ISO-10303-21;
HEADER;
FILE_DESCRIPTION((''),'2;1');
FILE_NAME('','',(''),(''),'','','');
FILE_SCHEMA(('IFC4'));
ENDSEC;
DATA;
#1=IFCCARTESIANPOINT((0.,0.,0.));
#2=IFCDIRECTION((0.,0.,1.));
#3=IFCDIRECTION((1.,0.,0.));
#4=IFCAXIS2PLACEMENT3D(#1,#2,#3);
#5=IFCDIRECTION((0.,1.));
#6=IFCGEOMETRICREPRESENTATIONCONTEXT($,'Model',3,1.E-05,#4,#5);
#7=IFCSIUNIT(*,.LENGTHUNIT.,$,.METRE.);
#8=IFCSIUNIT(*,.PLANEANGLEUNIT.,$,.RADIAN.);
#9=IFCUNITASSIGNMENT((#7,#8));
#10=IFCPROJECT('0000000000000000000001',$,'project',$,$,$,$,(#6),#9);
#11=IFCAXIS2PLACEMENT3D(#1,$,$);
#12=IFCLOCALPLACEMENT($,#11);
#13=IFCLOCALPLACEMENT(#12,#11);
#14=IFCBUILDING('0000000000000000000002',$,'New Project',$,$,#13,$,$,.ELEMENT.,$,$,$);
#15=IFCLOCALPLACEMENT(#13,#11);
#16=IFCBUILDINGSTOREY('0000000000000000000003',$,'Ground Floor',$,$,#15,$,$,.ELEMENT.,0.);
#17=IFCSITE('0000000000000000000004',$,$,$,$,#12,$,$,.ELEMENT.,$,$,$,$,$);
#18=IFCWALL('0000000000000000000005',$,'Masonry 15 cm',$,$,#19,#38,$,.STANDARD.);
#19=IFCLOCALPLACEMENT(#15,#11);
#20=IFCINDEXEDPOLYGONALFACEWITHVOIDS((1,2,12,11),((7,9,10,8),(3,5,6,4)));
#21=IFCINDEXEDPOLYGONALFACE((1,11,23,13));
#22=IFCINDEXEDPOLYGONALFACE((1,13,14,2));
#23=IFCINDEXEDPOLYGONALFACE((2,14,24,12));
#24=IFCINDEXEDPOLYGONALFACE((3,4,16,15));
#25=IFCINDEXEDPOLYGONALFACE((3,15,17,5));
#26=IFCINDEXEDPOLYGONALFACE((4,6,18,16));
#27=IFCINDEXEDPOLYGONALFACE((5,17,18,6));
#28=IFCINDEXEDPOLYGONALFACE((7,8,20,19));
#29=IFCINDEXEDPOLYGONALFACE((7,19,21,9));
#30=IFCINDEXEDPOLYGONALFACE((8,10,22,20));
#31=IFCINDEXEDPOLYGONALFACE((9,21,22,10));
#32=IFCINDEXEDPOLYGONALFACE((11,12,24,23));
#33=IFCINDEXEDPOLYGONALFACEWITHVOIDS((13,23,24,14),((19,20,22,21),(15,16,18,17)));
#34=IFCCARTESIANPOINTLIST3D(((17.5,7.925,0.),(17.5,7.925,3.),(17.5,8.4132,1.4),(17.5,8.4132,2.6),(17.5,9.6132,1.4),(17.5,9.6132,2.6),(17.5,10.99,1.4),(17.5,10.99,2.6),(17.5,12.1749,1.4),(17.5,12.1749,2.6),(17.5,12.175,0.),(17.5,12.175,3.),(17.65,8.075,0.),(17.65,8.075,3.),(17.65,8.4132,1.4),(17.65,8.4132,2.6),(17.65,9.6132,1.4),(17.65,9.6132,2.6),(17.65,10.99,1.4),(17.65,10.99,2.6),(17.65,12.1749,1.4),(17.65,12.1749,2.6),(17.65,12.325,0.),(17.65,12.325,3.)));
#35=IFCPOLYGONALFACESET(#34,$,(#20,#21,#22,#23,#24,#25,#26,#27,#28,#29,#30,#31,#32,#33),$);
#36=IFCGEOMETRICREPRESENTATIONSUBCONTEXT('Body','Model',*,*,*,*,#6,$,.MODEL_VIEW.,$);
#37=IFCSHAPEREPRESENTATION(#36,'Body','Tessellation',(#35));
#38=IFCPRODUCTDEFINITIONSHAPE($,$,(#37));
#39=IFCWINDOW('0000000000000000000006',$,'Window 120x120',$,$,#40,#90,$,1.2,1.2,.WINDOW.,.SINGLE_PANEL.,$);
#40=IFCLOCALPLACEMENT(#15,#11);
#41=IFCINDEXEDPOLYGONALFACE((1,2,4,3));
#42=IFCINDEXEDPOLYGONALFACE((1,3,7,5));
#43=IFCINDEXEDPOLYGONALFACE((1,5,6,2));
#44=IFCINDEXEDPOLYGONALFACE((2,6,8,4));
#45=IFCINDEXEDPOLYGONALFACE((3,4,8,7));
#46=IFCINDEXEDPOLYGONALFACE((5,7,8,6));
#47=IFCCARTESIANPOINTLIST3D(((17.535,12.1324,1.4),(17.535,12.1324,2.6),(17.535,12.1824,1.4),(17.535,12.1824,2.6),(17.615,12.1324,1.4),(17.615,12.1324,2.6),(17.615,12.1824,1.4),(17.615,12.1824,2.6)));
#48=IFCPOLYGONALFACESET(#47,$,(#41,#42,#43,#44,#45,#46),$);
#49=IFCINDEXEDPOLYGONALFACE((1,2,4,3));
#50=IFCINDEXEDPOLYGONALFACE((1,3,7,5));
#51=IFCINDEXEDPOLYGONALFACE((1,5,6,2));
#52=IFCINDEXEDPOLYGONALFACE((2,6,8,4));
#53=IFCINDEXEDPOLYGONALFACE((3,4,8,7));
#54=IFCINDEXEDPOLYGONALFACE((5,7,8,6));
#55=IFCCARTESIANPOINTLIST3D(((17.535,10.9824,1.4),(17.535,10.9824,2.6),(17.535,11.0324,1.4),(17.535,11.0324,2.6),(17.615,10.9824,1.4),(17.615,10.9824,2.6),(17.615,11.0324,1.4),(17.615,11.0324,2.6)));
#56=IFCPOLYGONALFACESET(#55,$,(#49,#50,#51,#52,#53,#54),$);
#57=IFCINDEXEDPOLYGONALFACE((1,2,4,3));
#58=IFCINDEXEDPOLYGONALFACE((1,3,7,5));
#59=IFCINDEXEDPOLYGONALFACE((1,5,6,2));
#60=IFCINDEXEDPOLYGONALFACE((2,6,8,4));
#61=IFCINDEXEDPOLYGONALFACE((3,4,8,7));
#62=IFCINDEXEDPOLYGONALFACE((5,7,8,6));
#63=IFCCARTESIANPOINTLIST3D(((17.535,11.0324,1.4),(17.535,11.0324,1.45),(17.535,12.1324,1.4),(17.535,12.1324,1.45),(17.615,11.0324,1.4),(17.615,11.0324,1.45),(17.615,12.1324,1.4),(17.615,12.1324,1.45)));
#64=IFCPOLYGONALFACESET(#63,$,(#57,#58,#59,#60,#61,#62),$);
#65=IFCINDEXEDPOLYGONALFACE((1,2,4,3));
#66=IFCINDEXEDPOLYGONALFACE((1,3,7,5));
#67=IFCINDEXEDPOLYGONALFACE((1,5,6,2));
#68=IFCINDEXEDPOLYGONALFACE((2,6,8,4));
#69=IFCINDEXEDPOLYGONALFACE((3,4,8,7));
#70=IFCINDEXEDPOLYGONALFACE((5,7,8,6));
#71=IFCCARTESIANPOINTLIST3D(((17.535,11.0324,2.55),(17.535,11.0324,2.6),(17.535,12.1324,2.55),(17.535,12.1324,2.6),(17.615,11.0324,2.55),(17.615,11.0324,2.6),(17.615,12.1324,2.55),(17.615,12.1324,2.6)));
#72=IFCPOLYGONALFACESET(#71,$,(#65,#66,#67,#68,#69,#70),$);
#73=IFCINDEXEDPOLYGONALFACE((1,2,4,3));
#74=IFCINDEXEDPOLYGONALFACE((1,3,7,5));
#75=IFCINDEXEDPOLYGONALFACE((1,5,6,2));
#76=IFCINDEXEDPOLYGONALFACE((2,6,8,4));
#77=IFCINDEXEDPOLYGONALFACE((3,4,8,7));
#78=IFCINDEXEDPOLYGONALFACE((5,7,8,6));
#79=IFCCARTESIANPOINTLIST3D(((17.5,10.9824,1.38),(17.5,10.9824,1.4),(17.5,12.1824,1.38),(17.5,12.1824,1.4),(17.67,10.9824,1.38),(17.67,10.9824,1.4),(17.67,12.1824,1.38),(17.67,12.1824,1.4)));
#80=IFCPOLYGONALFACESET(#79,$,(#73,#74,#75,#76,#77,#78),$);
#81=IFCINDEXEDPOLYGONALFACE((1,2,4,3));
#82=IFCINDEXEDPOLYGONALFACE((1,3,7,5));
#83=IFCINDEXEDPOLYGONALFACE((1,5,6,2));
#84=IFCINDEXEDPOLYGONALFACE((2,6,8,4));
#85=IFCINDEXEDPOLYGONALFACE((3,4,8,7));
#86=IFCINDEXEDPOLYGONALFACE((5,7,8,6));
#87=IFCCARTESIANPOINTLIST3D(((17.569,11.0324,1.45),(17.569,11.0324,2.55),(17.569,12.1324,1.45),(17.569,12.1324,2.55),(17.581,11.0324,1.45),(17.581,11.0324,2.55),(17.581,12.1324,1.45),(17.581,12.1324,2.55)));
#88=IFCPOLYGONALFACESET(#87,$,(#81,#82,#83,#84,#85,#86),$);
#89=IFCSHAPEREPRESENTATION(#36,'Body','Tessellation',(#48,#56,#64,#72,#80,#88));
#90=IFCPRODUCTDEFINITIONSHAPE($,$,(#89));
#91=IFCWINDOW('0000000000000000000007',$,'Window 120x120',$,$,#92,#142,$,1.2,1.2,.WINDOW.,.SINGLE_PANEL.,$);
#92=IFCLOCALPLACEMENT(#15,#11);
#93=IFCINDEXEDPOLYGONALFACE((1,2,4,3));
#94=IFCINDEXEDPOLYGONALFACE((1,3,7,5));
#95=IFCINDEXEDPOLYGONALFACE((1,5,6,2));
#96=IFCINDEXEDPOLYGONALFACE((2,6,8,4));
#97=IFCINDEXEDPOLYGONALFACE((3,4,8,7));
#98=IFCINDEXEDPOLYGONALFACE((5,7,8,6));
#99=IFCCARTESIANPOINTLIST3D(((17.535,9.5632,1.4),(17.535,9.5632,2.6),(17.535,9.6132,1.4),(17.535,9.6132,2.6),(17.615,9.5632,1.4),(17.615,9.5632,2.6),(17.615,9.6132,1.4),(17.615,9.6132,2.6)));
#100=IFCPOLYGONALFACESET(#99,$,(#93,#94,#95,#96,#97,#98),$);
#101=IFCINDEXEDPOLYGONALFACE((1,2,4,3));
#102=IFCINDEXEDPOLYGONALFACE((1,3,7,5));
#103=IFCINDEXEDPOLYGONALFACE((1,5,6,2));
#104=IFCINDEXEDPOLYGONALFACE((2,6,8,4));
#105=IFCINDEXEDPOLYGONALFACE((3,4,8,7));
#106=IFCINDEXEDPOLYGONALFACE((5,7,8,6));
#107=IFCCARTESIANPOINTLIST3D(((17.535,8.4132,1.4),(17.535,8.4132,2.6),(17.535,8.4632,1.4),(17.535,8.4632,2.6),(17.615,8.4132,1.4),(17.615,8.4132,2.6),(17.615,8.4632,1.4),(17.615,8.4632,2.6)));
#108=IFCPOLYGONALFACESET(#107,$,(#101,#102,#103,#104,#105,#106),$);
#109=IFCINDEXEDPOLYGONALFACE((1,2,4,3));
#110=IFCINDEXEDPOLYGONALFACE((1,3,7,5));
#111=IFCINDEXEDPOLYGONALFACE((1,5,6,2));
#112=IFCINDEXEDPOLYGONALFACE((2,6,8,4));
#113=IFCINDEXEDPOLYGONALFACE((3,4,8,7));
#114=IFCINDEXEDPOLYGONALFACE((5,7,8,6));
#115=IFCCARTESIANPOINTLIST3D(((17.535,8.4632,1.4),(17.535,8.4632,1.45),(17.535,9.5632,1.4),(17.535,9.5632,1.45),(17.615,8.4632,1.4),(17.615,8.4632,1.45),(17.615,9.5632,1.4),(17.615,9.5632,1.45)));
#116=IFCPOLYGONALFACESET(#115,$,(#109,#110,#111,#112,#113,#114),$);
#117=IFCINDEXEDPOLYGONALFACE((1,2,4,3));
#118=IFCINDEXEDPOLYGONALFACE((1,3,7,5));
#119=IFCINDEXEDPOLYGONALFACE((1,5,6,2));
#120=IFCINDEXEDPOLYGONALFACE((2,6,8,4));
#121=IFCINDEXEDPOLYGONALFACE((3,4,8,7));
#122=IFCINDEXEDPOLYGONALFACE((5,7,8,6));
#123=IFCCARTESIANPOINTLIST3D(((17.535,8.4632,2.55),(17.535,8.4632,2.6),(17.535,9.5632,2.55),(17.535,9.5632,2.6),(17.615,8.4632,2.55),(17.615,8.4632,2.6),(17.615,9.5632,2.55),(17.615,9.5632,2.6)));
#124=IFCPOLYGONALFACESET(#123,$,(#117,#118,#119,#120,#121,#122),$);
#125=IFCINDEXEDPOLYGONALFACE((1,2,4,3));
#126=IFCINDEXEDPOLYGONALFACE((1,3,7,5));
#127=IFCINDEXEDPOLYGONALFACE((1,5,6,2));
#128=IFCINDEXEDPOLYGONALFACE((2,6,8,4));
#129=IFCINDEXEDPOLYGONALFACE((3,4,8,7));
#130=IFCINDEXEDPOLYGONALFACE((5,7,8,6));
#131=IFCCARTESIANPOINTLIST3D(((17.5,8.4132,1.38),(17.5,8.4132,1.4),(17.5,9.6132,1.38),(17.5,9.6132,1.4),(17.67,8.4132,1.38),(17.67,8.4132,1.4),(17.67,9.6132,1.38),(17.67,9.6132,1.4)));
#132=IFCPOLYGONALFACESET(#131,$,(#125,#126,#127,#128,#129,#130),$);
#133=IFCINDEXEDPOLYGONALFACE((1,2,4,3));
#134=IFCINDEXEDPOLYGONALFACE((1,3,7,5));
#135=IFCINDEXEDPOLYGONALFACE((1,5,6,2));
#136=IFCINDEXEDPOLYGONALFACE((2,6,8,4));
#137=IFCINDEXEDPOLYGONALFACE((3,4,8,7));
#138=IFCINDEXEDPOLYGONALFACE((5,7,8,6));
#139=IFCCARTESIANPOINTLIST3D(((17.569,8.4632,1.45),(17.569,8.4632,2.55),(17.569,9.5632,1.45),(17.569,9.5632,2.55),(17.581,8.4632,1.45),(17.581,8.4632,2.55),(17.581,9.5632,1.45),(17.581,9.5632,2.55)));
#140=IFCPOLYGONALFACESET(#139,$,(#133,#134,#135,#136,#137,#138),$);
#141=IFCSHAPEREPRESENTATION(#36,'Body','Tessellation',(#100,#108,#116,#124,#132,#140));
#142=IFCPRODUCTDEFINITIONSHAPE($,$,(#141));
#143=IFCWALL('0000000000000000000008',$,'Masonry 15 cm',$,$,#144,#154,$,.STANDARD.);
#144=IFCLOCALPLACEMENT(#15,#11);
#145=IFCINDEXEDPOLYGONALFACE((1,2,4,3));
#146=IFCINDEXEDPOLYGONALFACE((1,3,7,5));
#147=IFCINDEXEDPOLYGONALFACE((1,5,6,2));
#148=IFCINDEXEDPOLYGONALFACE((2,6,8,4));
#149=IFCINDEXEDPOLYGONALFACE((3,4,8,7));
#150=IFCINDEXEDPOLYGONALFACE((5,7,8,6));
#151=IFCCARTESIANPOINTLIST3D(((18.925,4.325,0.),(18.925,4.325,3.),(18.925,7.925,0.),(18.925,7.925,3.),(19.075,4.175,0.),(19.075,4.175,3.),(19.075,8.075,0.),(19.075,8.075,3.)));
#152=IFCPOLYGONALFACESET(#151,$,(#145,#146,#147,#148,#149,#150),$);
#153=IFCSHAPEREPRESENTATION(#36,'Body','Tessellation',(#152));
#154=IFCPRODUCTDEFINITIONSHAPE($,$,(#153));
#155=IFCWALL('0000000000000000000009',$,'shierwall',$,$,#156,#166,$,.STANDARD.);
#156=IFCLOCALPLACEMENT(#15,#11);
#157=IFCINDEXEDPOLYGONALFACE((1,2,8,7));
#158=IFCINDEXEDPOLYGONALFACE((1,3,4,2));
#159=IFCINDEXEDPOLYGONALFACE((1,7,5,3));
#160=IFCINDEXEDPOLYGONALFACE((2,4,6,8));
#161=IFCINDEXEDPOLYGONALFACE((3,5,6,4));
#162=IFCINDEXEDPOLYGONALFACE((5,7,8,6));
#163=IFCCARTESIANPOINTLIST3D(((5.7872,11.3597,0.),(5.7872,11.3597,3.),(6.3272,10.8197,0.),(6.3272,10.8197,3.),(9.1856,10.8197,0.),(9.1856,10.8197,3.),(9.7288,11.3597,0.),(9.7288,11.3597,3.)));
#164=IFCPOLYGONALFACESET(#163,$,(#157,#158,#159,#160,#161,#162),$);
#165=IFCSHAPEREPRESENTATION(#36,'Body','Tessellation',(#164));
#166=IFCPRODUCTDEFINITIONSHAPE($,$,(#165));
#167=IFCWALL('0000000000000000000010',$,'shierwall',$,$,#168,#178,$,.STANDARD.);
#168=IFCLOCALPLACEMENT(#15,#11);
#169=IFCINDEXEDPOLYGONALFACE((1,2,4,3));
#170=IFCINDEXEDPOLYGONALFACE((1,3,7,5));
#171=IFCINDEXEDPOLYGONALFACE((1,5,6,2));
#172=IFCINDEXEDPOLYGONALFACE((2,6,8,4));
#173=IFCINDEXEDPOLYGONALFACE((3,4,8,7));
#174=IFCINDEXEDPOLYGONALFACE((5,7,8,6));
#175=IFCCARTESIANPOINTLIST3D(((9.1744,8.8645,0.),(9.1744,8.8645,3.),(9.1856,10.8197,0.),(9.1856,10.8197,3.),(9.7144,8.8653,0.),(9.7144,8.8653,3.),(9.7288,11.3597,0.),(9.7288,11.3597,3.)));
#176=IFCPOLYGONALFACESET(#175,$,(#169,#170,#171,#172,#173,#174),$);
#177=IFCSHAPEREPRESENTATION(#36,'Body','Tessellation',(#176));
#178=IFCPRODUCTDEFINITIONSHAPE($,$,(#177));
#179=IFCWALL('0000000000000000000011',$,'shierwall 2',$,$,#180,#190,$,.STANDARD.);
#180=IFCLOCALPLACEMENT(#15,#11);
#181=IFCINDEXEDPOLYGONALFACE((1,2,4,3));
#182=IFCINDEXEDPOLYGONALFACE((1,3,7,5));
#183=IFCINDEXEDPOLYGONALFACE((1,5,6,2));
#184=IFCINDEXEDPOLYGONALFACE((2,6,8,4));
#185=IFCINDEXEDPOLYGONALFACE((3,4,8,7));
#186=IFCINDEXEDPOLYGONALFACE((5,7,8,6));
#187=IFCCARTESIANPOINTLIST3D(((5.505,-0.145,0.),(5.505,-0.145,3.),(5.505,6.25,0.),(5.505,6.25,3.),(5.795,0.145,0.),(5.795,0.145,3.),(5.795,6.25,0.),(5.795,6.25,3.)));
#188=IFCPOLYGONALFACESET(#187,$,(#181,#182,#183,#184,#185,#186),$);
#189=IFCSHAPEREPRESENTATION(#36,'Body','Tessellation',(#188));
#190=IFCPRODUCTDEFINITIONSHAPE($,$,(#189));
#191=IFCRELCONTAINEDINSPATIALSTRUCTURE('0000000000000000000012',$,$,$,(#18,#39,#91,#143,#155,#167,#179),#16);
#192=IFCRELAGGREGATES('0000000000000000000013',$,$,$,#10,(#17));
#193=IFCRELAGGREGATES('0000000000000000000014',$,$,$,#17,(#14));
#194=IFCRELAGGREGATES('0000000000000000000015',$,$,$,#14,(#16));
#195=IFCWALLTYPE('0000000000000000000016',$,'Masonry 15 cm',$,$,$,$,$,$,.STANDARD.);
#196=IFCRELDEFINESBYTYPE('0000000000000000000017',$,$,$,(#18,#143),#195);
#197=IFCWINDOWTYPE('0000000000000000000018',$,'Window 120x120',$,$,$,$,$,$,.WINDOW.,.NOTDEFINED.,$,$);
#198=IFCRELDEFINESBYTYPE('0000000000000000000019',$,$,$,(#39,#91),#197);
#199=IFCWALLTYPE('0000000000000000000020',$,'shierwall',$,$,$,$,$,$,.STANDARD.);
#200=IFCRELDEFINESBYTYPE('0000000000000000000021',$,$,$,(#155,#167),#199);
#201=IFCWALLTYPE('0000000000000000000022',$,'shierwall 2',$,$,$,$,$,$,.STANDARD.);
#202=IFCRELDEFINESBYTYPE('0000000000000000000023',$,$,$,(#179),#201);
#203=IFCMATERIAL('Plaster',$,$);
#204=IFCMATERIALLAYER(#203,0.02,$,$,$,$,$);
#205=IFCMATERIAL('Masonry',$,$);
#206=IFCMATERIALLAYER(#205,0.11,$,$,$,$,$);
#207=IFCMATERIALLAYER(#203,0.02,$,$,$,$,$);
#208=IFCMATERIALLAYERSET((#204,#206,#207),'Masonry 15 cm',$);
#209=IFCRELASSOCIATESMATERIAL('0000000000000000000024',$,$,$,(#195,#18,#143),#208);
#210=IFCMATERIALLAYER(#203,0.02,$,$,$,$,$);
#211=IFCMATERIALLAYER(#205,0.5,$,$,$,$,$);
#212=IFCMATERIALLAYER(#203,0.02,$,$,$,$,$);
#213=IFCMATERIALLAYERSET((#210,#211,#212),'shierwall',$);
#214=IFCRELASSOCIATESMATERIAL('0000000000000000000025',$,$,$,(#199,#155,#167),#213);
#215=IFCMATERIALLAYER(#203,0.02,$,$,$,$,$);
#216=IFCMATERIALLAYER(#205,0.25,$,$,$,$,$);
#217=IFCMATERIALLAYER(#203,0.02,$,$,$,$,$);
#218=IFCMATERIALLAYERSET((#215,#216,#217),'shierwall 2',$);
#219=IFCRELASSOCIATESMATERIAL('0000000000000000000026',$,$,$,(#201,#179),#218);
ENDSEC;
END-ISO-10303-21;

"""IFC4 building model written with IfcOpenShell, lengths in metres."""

from ifc_helpers import new_model, si_unit, direction, frame, frame_2d, origin, origin_with_axes, place, context, subcontext, project, spatial, polyline, rectangle, outline, extrude, material, layer, layer_set, layer_usage, type_object, element, fill, save


model = new_model("IFC4")

# Units and contexts
model_context = context("Model", 3, precision=1e-05, world=origin_with_axes(), true_north=direction((0.0, 1.0)))
body_context = subcontext(model_context, "Body", "Model", "MODEL_VIEW")
ifc_project = project(units=[si_unit("LENGTHUNIT", "METRE"), si_unit("PLANEANGLEUNIT", "RADIAN")], contexts=[model_context])

# Site, building, storey
site_placement = place(None, origin())
site = spatial("IfcSite", under=ifc_project, at=site_placement, CompositionType="ELEMENT")
building_placement = place(site_placement, origin())
building = spatial("IfcBuilding", under=site, at=building_placement, Name="New Project", CompositionType="ELEMENT")
storey_placement = place(building_placement, origin())
storey = spatial("IfcBuildingStorey", under=building, at=storey_placement, Name="Ground Floor", CompositionType="ELEMENT", Elevation=0.0)

# Shared definitions
ifc_material_1 = material(Name="Plaster")
ifc_layer_1 = layer(ifc_material_1, 0.02)
ifc_material_2 = material(Name="Masonry")
ifc_layer_2 = layer(ifc_material_2, 0.11)
ifc_layer_3 = layer(ifc_material_1, 0.02)
ifc_layer_set_1 = layer_set([ifc_layer_1, ifc_layer_2, ifc_layer_3], Name="Masonry 15 cm")
ifc_layer_usage_1 = layer_usage(ifc_layer_set_1, "AXIS2", "NEGATIVE", 0.075)
wall_type_1 = type_object("IfcWallType", Name="Masonry 15 cm", PredefinedType="STANDARD", material=ifc_layer_set_1)

# Shared definitions
window_type = type_object("IfcWindowType", Name="Window 120x120", PartitioningType="NOTDEFINED", PredefinedType="WINDOW")

# Wall, openings, windows
wall_1_placement = place(storey_placement, frame((17.575, 12.25, 0.0), z_axis=(0.0, 0.0, 1.0), x_axis=(0.0, -1.0, 0.0)))
wall_1 = element("IfcWall", 1, at=wall_1_placement, inside=storey, type_object=wall_type_1, material=ifc_layer_usage_1, Name="Masonry 15 cm", PredefinedType="STANDARD", context=body_context, shape_type="SweptSolid", body=[
    extrude(outline(polyline([(0.075, -0.075), (4.325, -0.075), (4.175, 0.075), (-0.075, 0.075), (0.075, -0.075)])), origin(), (0.0, 0.0, 1.0), 3.0),
])
opening_1_placement = place(wall_1_placement, frame((0.0751, 0.0, 1.4)))
opening_1 = element("IfcOpeningElement", 2, at=opening_1_placement, cuts=wall_1, PredefinedType="OPENING", context=body_context, shape_type="SweptSolid", body=[
    extrude(rectangle(XDim=1.1849, YDim=0.25, at=frame_2d((0.5925, 0.0))), origin(), (0.0, 0.0, 1.0), 1.2),
])
opening_2_placement = place(wall_1_placement, frame((2.6368, 0.0, 1.4)))
opening_2 = element("IfcOpeningElement", 3, at=opening_2_placement, cuts=wall_1, PredefinedType="OPENING", context=body_context, shape_type="SweptSolid", body=[
    extrude(rectangle(XDim=1.2, YDim=0.25, at=frame_2d((0.6, 0.0))), origin(), (0.0, 0.0, 1.0), 1.2),
])
window_1_placement = place(opening_1_placement, origin())
window_1 = element("IfcWindow", 4, at=window_1_placement, inside=storey, type_object=window_type, Name="Window 120x120", OverallHeight=1.2, OverallWidth=1.2, PartitioningType="SINGLE_PANEL", PredefinedType="WINDOW", context=body_context, shape_type="SweptSolid", body=[
    extrude(outline(polyline([(-0.0076, -0.04), (0.0425, -0.04), (0.0425, 0.04), (-0.0076, 0.04), (-0.0076, -0.04)])), origin(), (0.0, 0.0, 1.0), 1.2),
    extrude(outline(polyline([(1.1424, -0.04), (1.1925, -0.04), (1.1925, 0.04), (1.1424, 0.04), (1.1424, -0.04)])), origin(), (0.0, 0.0, 1.0), 1.2),
    extrude(outline(polyline([(0.0425, -0.04), (1.1424, -0.04), (1.1424, 0.04), (0.0425, 0.04), (0.0425, -0.04)])), origin(), (0.0, 0.0, 1.0), 0.05),
    extrude(outline(polyline([(0.0425, -0.04), (1.1424, -0.04), (1.1424, 0.04), (0.0425, 0.04), (0.0425, -0.04)])), frame((0.0, 0.0, 1.15)), (0.0, 0.0, 1.0), 0.05),
    extrude(outline(polyline([(-0.0076, -0.075), (1.1925, -0.075), (1.1925, 0.095), (-0.0076, 0.095), (-0.0076, -0.075)])), frame((0.0, 0.0, -0.02)), (0.0, 0.0, 1.0), 0.02),
    extrude(outline(polyline([(0.0425, -0.006), (1.1424, -0.006), (1.1424, 0.006), (0.0425, 0.006), (0.0425, -0.006)])), frame((0.0, 0.0, 0.05)), (0.0, 0.0, 1.0), 1.1),
])
fill(opening_1, window_1)
window_2_placement = place(opening_2_placement, origin())
window_2 = element("IfcWindow", 5, at=window_2_placement, inside=storey, type_object=window_type, Name="Window 120x120", OverallHeight=1.2, OverallWidth=1.2, PartitioningType="SINGLE_PANEL", PredefinedType="WINDOW", context=body_context, shape_type="SweptSolid", body=[
    extrude(outline(polyline([(0.0, -0.04), (0.05, -0.04), (0.05, 0.04), (0.0, 0.04), (0.0, -0.04)])), origin(), (0.0, 0.0, 1.0), 1.2),
    extrude(outline(polyline([(1.15, -0.04), (1.2, -0.04), (1.2, 0.04), (1.15, 0.04), (1.15, -0.04)])), origin(), (0.0, 0.0, 1.0), 1.2),
    extrude(outline(polyline([(0.05, -0.04), (1.15, -0.04), (1.15, 0.04), (0.05, 0.04), (0.05, -0.04)])), origin(), (0.0, 0.0, 1.0), 0.05),
    extrude(outline(polyline([(0.05, -0.04), (1.15, -0.04), (1.15, 0.04), (0.05, 0.04), (0.05, -0.04)])), frame((0.0, 0.0, 1.15)), (0.0, 0.0, 1.0), 0.05),
    extrude(outline(polyline([(0.0, -0.075), (1.2, -0.075), (1.2, 0.095), (0.0, 0.095), (0.0, -0.075)])), frame((0.0, 0.0, -0.02)), (0.0, 0.0, 1.0), 0.02),
    extrude(outline(polyline([(0.05, -0.006), (1.15, -0.006), (1.15, 0.006), (0.05, 0.006), (0.05, -0.006)])), frame((0.0, 0.0, 0.05)), (0.0, 0.0, 1.0), 1.1),
])
fill(opening_2, window_2)

# Walls
wall_2_placement = place(storey_placement, frame((19.0, 8.0, 0.0), z_axis=(0.0, 0.0, 1.0), x_axis=(0.0, -1.0, 0.0)))
element("IfcWall", 6, at=wall_2_placement, inside=storey, type_object=wall_type_1, material=ifc_layer_usage_1, Name="Masonry 15 cm", PredefinedType="STANDARD", context=body_context, shape_type="SweptSolid", body=[
    extrude(outline(polyline([(0.075, -0.075), (3.675, -0.075), (3.825, 0.075), (-0.075, 0.075), (0.075, -0.075)])), origin(), (0.0, 0.0, 1.0), 3.0),
])
ifc_layer_4 = layer(ifc_material_1, 0.02)
ifc_layer_5 = layer(ifc_material_2, 0.5)
ifc_layer_6 = layer(ifc_material_1, 0.02)
ifc_layer_set_2 = layer_set([ifc_layer_4, ifc_layer_5, ifc_layer_6], Name="shierwall")
ifc_layer_usage_2 = layer_usage(ifc_layer_set_2, "AXIS2", "NEGATIVE", 0.27)
wall_type_2 = type_object("IfcWallType", Name="shierwall", PredefinedType="STANDARD", material=ifc_layer_set_2)
wall_3_placement = place(storey_placement, frame((6.0572, 11.0897, 0.0)))
element("IfcWall", 7, at=wall_3_placement, inside=storey, type_object=wall_type_2, material=ifc_layer_usage_2, Name="shierwall", PredefinedType="STANDARD", context=body_context, shape_type="SweptSolid", body=[
    extrude(outline(polyline([(0.27, -0.27), (3.1284, -0.27), (3.6716, 0.27), (-0.27, 0.27), (0.27, -0.27)])), origin(), (0.0, 0.0, 1.0), 3.0),
])
wall_4_placement = place(storey_placement, frame((9.4572, 11.0897, 0.0), z_axis=(0.0, 0.0, 1.0), x_axis=(-0.005766, -0.999983, 0.0)))
element("IfcWall", 8, at=wall_4_placement, inside=storey, type_object=wall_type_2, material=ifc_layer_usage_2, Name="shierwall", PredefinedType="STANDARD", context=body_context, shape_type="SweptSolid", body=[
    extrude(outline(polyline([(0.2716, -0.27), (2.2268, -0.27), (2.2229, 0.27), (-0.2716, 0.27), (0.2716, -0.27)])), origin(), (0.0, 0.0, 1.0), 3.0),
])
ifc_layer_7 = layer(ifc_material_1, 0.02)
ifc_layer_8 = layer(ifc_material_2, 0.25)
ifc_layer_9 = layer(ifc_material_1, 0.02)
ifc_layer_set_3 = layer_set([ifc_layer_7, ifc_layer_8, ifc_layer_9], Name="shierwall 2")
ifc_layer_usage_3 = layer_usage(ifc_layer_set_3, "AXIS2", "NEGATIVE", 0.145)
wall_type_3 = type_object("IfcWallType", Name="shierwall 2", PredefinedType="STANDARD", material=ifc_layer_set_3)
wall_5_placement = place(storey_placement, frame((5.65, 6.25, 0.0), z_axis=(0.0, 0.0, 1.0), x_axis=(0.0, -1.0, 0.0)))
element("IfcWall", 9, at=wall_5_placement, inside=storey, type_object=wall_type_3, material=ifc_layer_usage_3, Name="shierwall 2", PredefinedType="STANDARD", context=body_context, shape_type="SweptSolid", body=[
    extrude(outline(polyline([(0.0, -0.145), (6.395, -0.145), (6.105, 0.145), (0.0, 0.145), (0.0, -0.145)])), origin(), (0.0, 0.0, 1.0), 3.0),
])

save(model, "model.ifc")
